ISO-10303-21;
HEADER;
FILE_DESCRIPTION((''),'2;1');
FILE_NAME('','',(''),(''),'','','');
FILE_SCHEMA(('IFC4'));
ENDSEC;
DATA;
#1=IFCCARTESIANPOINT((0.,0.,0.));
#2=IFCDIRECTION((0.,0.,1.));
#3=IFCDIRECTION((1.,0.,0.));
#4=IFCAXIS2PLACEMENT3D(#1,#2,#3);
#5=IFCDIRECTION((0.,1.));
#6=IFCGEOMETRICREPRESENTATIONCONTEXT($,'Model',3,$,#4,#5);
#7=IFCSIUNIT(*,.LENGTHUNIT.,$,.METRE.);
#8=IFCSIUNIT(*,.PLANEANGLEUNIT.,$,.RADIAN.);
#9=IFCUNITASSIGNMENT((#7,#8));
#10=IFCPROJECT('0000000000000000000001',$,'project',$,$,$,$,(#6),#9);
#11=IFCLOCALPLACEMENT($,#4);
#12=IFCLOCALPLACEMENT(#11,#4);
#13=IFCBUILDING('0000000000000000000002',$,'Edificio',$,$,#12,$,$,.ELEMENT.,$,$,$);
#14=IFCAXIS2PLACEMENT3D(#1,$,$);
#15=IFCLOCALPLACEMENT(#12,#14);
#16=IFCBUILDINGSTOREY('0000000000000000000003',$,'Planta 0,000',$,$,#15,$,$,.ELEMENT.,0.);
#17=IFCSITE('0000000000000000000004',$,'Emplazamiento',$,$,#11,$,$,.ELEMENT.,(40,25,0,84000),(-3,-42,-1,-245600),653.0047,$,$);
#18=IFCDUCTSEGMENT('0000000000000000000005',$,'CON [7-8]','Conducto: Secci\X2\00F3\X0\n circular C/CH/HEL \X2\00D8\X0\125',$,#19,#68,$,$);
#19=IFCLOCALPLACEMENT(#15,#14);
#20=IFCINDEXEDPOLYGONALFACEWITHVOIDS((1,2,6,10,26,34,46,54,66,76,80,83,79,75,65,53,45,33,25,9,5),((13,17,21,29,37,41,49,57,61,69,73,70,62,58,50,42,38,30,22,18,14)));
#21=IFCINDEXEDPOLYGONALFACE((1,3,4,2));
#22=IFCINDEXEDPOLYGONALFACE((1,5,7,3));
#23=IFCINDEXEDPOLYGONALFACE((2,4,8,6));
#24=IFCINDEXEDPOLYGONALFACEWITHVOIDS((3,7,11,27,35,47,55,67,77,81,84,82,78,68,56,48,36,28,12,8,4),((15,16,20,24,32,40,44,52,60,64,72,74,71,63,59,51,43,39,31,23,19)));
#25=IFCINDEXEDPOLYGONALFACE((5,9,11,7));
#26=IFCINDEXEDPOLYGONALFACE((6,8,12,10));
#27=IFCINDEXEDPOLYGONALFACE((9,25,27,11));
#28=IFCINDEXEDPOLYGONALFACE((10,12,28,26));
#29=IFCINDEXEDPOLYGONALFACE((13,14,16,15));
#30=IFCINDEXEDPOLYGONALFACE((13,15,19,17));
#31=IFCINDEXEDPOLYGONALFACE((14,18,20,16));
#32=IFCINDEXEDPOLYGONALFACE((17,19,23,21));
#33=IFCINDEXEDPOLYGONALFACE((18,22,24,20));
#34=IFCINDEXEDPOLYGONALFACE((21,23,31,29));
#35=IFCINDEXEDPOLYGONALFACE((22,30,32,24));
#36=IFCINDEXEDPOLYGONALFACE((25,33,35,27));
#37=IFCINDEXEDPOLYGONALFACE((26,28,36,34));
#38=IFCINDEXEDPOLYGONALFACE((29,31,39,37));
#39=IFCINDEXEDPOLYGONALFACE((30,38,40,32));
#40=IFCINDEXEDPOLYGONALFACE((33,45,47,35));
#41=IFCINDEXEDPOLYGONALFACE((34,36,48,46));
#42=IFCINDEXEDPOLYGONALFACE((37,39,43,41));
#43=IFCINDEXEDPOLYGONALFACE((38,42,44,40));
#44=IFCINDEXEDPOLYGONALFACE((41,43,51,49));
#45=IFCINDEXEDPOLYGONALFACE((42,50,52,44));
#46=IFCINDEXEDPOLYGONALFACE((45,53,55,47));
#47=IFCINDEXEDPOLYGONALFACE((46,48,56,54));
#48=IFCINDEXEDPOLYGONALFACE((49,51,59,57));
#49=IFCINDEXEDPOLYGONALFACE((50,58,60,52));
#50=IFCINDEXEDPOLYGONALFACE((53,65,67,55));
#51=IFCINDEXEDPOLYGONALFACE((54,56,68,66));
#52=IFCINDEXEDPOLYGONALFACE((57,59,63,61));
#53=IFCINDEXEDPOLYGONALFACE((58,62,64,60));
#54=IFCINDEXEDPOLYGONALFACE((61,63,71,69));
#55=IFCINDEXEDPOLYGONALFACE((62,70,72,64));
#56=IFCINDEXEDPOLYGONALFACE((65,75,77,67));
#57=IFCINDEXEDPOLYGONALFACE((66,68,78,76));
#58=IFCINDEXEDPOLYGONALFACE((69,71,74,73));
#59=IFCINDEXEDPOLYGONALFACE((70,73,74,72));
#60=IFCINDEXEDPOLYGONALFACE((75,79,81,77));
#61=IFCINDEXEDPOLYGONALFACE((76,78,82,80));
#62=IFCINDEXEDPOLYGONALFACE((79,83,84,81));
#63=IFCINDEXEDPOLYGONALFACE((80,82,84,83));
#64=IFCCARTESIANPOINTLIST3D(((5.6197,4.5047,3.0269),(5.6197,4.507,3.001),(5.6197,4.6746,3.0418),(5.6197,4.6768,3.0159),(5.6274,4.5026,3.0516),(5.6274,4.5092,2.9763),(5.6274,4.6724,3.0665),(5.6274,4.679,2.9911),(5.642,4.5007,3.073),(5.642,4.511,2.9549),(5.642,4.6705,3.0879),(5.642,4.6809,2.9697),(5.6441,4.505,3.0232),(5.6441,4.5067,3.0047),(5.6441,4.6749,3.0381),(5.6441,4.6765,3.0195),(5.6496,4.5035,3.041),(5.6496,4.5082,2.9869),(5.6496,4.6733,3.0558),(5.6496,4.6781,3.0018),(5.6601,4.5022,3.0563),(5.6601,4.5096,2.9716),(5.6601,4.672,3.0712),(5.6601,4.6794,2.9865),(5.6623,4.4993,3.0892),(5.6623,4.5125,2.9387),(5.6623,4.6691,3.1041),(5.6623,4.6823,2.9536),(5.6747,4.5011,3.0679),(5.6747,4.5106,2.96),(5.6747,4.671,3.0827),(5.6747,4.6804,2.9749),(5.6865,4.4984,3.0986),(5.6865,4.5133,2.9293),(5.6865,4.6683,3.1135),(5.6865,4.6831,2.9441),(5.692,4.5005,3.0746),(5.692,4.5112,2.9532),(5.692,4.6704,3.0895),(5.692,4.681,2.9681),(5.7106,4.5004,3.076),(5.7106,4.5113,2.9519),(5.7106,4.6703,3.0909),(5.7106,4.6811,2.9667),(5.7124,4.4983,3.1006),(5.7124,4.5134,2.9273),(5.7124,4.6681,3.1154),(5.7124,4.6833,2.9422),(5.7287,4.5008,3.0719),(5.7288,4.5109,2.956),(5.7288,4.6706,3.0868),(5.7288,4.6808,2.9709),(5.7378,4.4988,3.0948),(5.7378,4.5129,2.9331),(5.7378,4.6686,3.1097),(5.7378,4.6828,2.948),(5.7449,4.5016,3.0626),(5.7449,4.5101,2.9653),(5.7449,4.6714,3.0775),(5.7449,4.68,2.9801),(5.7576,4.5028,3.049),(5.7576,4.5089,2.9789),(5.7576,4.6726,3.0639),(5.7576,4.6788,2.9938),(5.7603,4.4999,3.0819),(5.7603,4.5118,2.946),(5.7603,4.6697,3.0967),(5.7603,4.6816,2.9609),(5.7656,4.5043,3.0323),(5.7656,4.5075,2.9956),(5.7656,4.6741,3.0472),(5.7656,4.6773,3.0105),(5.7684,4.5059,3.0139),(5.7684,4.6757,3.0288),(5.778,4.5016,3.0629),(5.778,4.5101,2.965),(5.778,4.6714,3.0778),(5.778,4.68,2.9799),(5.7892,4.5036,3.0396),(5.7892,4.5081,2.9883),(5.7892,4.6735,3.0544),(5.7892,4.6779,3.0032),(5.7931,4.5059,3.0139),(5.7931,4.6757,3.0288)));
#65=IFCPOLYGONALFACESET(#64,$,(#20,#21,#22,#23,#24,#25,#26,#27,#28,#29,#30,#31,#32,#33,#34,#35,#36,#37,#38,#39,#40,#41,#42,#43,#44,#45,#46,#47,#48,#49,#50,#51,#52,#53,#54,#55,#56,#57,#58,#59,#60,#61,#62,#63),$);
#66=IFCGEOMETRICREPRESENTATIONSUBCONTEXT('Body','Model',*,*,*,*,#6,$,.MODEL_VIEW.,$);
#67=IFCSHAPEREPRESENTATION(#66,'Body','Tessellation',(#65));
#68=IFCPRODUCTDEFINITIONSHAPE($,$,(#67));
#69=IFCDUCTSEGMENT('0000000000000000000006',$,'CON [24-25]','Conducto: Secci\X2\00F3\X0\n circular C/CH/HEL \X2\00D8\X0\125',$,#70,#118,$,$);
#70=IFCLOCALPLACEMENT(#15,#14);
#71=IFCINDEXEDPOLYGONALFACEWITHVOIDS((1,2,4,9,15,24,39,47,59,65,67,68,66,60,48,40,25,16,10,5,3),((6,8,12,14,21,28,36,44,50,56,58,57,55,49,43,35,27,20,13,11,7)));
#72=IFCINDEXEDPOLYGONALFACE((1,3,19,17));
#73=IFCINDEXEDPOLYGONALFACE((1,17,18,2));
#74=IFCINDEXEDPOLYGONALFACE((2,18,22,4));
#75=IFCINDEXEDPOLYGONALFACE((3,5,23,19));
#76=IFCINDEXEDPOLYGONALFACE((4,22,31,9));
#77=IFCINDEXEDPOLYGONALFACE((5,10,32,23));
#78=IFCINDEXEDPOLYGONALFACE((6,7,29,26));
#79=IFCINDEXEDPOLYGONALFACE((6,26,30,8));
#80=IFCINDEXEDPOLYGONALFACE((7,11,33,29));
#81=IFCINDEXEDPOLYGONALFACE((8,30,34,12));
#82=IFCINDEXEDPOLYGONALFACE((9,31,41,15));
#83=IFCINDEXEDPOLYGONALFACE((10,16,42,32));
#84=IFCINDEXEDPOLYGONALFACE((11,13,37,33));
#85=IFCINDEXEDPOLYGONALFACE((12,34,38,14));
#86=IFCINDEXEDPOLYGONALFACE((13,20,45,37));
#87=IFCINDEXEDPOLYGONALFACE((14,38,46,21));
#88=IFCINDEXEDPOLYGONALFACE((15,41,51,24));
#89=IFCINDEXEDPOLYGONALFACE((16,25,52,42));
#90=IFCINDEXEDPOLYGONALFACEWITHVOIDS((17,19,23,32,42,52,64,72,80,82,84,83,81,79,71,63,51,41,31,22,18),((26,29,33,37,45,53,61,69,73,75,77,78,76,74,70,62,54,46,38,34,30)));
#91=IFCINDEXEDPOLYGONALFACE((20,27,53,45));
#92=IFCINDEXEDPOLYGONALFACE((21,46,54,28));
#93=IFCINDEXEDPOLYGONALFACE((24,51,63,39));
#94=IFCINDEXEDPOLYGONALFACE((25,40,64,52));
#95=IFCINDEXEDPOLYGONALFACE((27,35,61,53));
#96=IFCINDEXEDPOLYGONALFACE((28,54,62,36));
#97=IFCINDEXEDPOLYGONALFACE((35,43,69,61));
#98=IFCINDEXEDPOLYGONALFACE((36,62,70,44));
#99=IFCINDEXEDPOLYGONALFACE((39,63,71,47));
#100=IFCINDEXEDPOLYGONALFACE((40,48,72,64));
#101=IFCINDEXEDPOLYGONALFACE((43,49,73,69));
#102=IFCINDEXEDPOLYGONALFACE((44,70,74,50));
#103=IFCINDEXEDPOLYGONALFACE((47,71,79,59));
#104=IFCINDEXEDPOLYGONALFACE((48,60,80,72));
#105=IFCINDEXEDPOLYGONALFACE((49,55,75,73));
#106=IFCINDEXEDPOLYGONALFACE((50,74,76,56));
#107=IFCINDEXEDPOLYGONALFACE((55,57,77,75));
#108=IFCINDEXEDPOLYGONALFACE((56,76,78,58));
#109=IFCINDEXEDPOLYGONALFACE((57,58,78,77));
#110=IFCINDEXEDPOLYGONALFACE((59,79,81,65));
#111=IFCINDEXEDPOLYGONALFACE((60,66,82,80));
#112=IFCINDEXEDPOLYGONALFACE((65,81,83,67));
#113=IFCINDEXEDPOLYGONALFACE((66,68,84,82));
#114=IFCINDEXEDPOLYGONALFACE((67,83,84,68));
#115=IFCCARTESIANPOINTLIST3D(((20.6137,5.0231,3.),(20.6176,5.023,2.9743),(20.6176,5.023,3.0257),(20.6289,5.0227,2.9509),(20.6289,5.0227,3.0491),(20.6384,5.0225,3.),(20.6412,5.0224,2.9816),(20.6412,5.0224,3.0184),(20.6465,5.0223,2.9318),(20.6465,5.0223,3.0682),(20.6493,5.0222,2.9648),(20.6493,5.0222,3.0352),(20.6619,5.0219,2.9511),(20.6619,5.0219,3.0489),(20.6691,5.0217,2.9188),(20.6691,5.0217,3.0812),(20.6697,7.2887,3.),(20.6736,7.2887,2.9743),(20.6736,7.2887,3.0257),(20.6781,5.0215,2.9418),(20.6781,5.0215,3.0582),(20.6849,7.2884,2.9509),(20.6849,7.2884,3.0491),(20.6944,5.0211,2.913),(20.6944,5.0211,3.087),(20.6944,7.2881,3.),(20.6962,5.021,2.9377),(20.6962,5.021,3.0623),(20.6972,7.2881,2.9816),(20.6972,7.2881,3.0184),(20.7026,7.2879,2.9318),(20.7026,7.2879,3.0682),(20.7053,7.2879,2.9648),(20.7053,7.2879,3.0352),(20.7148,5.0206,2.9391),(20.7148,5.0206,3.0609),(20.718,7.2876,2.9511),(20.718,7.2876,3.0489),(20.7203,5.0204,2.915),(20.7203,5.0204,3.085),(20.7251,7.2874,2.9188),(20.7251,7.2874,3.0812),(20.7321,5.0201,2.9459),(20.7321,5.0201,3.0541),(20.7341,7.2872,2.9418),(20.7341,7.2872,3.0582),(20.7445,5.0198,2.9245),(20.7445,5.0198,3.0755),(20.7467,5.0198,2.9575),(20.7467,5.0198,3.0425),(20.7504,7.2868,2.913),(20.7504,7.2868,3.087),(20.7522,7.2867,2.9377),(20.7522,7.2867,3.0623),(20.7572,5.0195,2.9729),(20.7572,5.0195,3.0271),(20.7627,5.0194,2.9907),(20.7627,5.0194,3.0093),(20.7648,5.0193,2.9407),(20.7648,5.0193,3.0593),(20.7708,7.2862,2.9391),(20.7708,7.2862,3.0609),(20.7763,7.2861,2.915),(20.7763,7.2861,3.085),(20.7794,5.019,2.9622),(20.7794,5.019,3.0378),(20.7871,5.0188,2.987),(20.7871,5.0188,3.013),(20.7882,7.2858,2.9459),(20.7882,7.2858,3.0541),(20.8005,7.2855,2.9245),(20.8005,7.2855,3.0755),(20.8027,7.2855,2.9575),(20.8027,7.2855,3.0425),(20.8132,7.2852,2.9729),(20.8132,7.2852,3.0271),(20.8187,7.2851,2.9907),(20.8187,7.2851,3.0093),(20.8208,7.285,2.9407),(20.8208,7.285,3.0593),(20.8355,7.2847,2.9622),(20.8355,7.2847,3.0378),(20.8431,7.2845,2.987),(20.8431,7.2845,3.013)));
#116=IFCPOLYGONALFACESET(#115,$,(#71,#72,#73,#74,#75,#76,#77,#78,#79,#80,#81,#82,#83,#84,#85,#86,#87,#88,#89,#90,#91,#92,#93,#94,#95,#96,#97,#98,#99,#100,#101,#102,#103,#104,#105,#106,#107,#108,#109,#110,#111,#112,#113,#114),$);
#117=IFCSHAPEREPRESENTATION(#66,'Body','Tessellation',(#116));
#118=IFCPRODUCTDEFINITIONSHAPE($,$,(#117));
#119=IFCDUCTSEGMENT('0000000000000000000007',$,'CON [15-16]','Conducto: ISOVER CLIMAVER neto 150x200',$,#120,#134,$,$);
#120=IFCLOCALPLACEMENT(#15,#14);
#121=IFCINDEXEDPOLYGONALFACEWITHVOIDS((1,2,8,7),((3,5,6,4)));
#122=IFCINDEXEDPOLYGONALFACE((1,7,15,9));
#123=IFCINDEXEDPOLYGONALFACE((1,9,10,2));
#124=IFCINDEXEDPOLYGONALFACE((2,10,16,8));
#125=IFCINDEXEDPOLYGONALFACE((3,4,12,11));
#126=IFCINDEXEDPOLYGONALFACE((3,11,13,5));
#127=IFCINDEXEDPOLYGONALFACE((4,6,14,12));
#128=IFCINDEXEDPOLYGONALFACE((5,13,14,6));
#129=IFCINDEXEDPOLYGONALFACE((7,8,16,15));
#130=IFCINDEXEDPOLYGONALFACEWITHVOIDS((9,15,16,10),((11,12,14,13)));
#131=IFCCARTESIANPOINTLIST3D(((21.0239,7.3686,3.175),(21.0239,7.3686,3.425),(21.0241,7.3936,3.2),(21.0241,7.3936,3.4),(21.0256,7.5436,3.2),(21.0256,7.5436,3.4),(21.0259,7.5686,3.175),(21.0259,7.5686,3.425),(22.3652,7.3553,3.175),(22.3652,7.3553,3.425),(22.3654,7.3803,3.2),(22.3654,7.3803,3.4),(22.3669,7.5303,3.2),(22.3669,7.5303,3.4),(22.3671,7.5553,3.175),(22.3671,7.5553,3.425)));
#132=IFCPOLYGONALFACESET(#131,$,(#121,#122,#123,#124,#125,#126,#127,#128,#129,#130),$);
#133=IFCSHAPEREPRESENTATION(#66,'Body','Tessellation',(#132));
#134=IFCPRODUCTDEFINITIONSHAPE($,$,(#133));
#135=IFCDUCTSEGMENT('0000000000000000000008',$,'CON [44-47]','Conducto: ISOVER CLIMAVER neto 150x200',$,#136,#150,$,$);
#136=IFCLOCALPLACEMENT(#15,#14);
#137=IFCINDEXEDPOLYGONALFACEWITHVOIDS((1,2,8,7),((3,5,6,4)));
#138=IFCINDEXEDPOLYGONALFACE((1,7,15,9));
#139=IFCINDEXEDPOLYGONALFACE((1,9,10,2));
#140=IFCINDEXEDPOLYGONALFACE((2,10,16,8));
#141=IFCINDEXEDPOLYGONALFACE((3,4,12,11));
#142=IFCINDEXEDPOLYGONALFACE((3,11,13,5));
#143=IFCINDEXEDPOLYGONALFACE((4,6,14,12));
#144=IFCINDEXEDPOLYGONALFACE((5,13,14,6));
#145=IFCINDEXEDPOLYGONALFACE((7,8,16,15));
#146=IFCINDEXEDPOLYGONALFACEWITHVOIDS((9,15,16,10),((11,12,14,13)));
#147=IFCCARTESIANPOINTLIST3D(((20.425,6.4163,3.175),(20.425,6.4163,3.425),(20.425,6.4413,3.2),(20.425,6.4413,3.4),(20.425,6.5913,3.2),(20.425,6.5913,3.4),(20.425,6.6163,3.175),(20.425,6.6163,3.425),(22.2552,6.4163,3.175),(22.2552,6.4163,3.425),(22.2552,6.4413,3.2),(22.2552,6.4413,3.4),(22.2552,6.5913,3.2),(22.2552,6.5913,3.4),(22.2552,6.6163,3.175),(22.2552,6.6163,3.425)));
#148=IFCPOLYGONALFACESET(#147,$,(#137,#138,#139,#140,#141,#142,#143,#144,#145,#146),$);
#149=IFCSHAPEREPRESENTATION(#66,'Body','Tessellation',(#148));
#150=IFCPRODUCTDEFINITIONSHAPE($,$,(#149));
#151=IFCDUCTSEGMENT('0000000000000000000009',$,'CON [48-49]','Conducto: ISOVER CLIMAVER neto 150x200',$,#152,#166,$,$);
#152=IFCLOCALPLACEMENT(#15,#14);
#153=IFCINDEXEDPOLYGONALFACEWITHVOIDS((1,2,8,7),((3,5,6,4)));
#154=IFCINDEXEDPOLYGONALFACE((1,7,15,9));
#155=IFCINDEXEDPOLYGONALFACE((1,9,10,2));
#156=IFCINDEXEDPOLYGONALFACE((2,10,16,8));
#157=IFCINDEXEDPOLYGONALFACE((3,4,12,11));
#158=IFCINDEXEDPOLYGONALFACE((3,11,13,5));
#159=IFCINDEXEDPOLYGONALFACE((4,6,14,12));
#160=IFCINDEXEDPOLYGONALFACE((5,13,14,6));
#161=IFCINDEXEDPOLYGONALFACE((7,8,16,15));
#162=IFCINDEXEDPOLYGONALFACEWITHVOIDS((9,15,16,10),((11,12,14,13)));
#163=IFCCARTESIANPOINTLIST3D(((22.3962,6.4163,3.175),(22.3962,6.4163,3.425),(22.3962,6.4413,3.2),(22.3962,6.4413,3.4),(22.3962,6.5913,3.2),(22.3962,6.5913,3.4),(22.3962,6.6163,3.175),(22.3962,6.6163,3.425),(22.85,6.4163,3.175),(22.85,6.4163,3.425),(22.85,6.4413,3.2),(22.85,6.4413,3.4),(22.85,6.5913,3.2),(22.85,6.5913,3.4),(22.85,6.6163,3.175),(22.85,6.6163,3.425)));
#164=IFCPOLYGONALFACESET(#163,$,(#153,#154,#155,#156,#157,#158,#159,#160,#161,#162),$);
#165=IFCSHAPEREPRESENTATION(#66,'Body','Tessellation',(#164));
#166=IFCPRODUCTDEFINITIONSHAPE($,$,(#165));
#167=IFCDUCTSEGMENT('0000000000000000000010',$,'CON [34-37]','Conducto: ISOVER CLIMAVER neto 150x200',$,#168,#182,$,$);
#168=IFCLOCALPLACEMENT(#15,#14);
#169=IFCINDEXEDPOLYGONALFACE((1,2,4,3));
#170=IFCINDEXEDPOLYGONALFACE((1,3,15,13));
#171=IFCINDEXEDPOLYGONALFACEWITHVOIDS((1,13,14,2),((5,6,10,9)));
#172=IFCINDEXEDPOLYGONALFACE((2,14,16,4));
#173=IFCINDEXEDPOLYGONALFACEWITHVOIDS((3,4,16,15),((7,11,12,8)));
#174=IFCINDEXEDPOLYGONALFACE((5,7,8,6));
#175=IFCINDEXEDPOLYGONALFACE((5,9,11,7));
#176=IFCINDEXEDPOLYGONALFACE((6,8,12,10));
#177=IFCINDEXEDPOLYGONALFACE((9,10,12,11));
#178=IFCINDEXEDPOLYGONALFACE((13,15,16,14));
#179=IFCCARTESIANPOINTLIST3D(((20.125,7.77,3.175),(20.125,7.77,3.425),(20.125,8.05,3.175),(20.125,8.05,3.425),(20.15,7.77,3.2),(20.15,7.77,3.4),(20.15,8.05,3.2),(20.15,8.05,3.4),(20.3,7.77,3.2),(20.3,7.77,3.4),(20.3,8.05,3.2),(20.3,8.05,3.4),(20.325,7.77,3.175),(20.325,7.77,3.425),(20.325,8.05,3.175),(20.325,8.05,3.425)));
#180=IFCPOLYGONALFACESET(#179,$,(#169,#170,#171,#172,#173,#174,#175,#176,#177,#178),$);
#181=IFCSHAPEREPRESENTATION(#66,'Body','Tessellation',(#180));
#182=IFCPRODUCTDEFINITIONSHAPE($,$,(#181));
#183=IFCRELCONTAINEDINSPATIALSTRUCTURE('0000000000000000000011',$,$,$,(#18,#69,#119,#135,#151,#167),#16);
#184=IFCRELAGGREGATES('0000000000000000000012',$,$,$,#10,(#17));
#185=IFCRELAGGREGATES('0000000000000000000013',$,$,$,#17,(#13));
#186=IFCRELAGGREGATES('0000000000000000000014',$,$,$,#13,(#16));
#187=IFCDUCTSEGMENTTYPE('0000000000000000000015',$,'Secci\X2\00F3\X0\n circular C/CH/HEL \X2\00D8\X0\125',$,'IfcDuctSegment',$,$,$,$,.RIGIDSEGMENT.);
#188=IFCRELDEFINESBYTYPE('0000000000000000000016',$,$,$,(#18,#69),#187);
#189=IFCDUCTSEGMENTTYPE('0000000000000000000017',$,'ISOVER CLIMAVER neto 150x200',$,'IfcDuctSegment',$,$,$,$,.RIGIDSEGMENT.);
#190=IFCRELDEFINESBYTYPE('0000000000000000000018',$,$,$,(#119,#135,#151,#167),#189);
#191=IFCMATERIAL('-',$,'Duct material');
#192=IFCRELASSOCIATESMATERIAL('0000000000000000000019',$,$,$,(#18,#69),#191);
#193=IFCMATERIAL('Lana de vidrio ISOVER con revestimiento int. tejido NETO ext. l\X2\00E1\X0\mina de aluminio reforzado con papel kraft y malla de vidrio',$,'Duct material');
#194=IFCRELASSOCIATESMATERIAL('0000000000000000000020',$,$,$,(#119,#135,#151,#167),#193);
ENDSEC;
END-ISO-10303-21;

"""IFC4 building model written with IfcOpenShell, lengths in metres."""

from ifc_helpers import new_model, si_unit, direction, frame, origin, origin_with_axes, origin_2d_with_axis, place, context, subcontext, project, spatial, hollow_rectangle, hollow_circle, extrude, material, type_object, element, save


model = new_model("IFC4")

# Units and contexts
model_context = context("Model", 3, world=origin_with_axes(), true_north=direction((0.0, 1.0)))
body_context = subcontext(model_context, "Body", "Model", "MODEL_VIEW")
ifc_project = project(units=[si_unit("LENGTHUNIT", "METRE"), si_unit("PLANEANGLEUNIT", "RADIAN")], contexts=[model_context])

# Site, building, storey
site_placement = place(None, origin_with_axes())
site = spatial("IfcSite", under=ifc_project, at=site_placement, Name="Emplazamiento", CompositionType="ELEMENT", RefLatitude=(40, 25, 0, 84000), RefLongitude=(-3, -42, -1, -245600), RefElevation=653.0047)
building_placement = place(site_placement, origin_with_axes())
building = spatial("IfcBuilding", under=site, at=building_placement, Name="Edificio", CompositionType="ELEMENT")
storey_placement = place(building_placement, origin())
storey = spatial("IfcBuildingStorey", under=building, at=storey_placement, Name="Planta 0,000", CompositionType="ELEMENT", Elevation=0.0)

# Shared definitions
ifc_material_1 = material(Name="-", Category="Duct material")

# Duct segments
ifc_material_2 = material(Name="Lana de vidrio ISOVER con revestimiento int. tejido NETO ext. lámina de aluminio reforzado con papel kraft y malla de vidrio", Category="Duct material")
duct_segment_type_1 = type_object("IfcDuctSegmentType", Name="Sección circular C/CH/HEL Ø125", ApplicableOccurrence="IfcDuctSegment", PredefinedType="RIGIDSEGMENT")
duct_segment_1_placement = place(storey_placement, origin_with_axes())
element("IfcDuctSegment", 1, at=duct_segment_1_placement, inside=storey, type_object=duct_segment_type_1, material=ifc_material_1, Name="CON [7-8]", Description="Conducto: Sección circular C/CH/HEL Ø125", context=body_context, shape_type="SweptSolid", body=[
    extrude(hollow_circle(Radius=0.0872, WallThickness=0.0247, at=origin_2d_with_axis()), frame((5.7059, 4.6757, 3.0288), z_axis=(-0.000024, -0.996184, -0.087276), x_axis=(1.0, -0.000024, 0.0)), (0.0, 0.0, 1.0), 0.1705),
])
duct_segment_2_placement = place(storey_placement, origin_with_axes())
element("IfcDuctSegment", 2, at=duct_segment_2_placement, inside=storey, type_object=duct_segment_type_1, material=ifc_material_1, Name="CON [24-25]", Description="Conducto: Sección circular C/CH/HEL Ø125", context=body_context, shape_type="SweptSolid", body=[
    extrude(hollow_circle(Radius=0.0872, WallThickness=0.0247, at=origin_2d_with_axis()), frame((20.7009, 5.0209, 3.0), z_axis=(0.024715, 0.999695, 0.0), x_axis=(-0.999695, 0.024715, 0.0)), (0.0, 0.0, 1.0), 2.2664),
])

# Duct segments
duct_segment_type_2 = type_object("IfcDuctSegmentType", Name="ISOVER CLIMAVER neto 150x200", ApplicableOccurrence="IfcDuctSegment", PredefinedType="RIGIDSEGMENT")
duct_segment_3_placement = place(storey_placement, origin_with_axes())
element("IfcDuctSegment", 3, at=duct_segment_3_placement, inside=storey, type_object=duct_segment_type_2, material=ifc_material_2, Name="CON [15-16]", Description="Conducto: ISOVER CLIMAVER neto 150x200", context=body_context, shape_type="SweptSolid", body=[
    extrude(hollow_rectangle(XDim=0.2, YDim=0.25, WallThickness=0.025, at=origin_2d_with_axis()), frame((22.3662, 7.4553, 3.3), z_axis=(-0.999951, 0.009885, 0.0), x_axis=(-0.009885, -0.999951, 0.0)), (0.0, 0.0, 1.0), 1.3414),
])
duct_segment_4_placement = place(storey_placement, origin_with_axes())
element("IfcDuctSegment", 4, at=duct_segment_4_placement, inside=storey, type_object=duct_segment_type_2, material=ifc_material_2, Name="CON [44-47]", Description="Conducto: ISOVER CLIMAVER neto 150x200", context=body_context, shape_type="SweptSolid", body=[
    extrude(hollow_rectangle(XDim=0.2, YDim=0.25, WallThickness=0.025, at=origin_2d_with_axis()), frame((20.425, 6.5163, 3.3), z_axis=(1.0, 0.0, 0.0), x_axis=(0.0, 1.0, 0.0)), (0.0, 0.0, 1.0), 1.8302),
])
duct_segment_5_placement = place(storey_placement, origin_with_axes())
element("IfcDuctSegment", 5, at=duct_segment_5_placement, inside=storey, type_object=duct_segment_type_2, material=ifc_material_2, Name="CON [48-49]", Description="Conducto: ISOVER CLIMAVER neto 150x200", context=body_context, shape_type="SweptSolid", body=[
    extrude(hollow_rectangle(XDim=0.2, YDim=0.25, WallThickness=0.025, at=origin_2d_with_axis()), frame((22.3962, 6.5163, 3.3), z_axis=(1.0, 0.0, 0.0), x_axis=(0.0, 1.0, 0.0)), (0.0, 0.0, 1.0), 0.4538),
])
duct_segment_6_placement = place(storey_placement, origin_with_axes())
element("IfcDuctSegment", 6, at=duct_segment_6_placement, inside=storey, type_object=duct_segment_type_2, material=ifc_material_2, Name="CON [34-37]", Description="Conducto: ISOVER CLIMAVER neto 150x200", context=body_context, shape_type="SweptSolid", body=[
    extrude(hollow_rectangle(XDim=0.2, YDim=0.25, WallThickness=0.025, at=origin_2d_with_axis()), frame((20.225, 7.77, 3.3), z_axis=(0.0, 1.0, 0.0), x_axis=(-1.0, 0.0, 0.0)), (0.0, 0.0, 1.0), 0.28),
])

save(model, "model.ifc")
